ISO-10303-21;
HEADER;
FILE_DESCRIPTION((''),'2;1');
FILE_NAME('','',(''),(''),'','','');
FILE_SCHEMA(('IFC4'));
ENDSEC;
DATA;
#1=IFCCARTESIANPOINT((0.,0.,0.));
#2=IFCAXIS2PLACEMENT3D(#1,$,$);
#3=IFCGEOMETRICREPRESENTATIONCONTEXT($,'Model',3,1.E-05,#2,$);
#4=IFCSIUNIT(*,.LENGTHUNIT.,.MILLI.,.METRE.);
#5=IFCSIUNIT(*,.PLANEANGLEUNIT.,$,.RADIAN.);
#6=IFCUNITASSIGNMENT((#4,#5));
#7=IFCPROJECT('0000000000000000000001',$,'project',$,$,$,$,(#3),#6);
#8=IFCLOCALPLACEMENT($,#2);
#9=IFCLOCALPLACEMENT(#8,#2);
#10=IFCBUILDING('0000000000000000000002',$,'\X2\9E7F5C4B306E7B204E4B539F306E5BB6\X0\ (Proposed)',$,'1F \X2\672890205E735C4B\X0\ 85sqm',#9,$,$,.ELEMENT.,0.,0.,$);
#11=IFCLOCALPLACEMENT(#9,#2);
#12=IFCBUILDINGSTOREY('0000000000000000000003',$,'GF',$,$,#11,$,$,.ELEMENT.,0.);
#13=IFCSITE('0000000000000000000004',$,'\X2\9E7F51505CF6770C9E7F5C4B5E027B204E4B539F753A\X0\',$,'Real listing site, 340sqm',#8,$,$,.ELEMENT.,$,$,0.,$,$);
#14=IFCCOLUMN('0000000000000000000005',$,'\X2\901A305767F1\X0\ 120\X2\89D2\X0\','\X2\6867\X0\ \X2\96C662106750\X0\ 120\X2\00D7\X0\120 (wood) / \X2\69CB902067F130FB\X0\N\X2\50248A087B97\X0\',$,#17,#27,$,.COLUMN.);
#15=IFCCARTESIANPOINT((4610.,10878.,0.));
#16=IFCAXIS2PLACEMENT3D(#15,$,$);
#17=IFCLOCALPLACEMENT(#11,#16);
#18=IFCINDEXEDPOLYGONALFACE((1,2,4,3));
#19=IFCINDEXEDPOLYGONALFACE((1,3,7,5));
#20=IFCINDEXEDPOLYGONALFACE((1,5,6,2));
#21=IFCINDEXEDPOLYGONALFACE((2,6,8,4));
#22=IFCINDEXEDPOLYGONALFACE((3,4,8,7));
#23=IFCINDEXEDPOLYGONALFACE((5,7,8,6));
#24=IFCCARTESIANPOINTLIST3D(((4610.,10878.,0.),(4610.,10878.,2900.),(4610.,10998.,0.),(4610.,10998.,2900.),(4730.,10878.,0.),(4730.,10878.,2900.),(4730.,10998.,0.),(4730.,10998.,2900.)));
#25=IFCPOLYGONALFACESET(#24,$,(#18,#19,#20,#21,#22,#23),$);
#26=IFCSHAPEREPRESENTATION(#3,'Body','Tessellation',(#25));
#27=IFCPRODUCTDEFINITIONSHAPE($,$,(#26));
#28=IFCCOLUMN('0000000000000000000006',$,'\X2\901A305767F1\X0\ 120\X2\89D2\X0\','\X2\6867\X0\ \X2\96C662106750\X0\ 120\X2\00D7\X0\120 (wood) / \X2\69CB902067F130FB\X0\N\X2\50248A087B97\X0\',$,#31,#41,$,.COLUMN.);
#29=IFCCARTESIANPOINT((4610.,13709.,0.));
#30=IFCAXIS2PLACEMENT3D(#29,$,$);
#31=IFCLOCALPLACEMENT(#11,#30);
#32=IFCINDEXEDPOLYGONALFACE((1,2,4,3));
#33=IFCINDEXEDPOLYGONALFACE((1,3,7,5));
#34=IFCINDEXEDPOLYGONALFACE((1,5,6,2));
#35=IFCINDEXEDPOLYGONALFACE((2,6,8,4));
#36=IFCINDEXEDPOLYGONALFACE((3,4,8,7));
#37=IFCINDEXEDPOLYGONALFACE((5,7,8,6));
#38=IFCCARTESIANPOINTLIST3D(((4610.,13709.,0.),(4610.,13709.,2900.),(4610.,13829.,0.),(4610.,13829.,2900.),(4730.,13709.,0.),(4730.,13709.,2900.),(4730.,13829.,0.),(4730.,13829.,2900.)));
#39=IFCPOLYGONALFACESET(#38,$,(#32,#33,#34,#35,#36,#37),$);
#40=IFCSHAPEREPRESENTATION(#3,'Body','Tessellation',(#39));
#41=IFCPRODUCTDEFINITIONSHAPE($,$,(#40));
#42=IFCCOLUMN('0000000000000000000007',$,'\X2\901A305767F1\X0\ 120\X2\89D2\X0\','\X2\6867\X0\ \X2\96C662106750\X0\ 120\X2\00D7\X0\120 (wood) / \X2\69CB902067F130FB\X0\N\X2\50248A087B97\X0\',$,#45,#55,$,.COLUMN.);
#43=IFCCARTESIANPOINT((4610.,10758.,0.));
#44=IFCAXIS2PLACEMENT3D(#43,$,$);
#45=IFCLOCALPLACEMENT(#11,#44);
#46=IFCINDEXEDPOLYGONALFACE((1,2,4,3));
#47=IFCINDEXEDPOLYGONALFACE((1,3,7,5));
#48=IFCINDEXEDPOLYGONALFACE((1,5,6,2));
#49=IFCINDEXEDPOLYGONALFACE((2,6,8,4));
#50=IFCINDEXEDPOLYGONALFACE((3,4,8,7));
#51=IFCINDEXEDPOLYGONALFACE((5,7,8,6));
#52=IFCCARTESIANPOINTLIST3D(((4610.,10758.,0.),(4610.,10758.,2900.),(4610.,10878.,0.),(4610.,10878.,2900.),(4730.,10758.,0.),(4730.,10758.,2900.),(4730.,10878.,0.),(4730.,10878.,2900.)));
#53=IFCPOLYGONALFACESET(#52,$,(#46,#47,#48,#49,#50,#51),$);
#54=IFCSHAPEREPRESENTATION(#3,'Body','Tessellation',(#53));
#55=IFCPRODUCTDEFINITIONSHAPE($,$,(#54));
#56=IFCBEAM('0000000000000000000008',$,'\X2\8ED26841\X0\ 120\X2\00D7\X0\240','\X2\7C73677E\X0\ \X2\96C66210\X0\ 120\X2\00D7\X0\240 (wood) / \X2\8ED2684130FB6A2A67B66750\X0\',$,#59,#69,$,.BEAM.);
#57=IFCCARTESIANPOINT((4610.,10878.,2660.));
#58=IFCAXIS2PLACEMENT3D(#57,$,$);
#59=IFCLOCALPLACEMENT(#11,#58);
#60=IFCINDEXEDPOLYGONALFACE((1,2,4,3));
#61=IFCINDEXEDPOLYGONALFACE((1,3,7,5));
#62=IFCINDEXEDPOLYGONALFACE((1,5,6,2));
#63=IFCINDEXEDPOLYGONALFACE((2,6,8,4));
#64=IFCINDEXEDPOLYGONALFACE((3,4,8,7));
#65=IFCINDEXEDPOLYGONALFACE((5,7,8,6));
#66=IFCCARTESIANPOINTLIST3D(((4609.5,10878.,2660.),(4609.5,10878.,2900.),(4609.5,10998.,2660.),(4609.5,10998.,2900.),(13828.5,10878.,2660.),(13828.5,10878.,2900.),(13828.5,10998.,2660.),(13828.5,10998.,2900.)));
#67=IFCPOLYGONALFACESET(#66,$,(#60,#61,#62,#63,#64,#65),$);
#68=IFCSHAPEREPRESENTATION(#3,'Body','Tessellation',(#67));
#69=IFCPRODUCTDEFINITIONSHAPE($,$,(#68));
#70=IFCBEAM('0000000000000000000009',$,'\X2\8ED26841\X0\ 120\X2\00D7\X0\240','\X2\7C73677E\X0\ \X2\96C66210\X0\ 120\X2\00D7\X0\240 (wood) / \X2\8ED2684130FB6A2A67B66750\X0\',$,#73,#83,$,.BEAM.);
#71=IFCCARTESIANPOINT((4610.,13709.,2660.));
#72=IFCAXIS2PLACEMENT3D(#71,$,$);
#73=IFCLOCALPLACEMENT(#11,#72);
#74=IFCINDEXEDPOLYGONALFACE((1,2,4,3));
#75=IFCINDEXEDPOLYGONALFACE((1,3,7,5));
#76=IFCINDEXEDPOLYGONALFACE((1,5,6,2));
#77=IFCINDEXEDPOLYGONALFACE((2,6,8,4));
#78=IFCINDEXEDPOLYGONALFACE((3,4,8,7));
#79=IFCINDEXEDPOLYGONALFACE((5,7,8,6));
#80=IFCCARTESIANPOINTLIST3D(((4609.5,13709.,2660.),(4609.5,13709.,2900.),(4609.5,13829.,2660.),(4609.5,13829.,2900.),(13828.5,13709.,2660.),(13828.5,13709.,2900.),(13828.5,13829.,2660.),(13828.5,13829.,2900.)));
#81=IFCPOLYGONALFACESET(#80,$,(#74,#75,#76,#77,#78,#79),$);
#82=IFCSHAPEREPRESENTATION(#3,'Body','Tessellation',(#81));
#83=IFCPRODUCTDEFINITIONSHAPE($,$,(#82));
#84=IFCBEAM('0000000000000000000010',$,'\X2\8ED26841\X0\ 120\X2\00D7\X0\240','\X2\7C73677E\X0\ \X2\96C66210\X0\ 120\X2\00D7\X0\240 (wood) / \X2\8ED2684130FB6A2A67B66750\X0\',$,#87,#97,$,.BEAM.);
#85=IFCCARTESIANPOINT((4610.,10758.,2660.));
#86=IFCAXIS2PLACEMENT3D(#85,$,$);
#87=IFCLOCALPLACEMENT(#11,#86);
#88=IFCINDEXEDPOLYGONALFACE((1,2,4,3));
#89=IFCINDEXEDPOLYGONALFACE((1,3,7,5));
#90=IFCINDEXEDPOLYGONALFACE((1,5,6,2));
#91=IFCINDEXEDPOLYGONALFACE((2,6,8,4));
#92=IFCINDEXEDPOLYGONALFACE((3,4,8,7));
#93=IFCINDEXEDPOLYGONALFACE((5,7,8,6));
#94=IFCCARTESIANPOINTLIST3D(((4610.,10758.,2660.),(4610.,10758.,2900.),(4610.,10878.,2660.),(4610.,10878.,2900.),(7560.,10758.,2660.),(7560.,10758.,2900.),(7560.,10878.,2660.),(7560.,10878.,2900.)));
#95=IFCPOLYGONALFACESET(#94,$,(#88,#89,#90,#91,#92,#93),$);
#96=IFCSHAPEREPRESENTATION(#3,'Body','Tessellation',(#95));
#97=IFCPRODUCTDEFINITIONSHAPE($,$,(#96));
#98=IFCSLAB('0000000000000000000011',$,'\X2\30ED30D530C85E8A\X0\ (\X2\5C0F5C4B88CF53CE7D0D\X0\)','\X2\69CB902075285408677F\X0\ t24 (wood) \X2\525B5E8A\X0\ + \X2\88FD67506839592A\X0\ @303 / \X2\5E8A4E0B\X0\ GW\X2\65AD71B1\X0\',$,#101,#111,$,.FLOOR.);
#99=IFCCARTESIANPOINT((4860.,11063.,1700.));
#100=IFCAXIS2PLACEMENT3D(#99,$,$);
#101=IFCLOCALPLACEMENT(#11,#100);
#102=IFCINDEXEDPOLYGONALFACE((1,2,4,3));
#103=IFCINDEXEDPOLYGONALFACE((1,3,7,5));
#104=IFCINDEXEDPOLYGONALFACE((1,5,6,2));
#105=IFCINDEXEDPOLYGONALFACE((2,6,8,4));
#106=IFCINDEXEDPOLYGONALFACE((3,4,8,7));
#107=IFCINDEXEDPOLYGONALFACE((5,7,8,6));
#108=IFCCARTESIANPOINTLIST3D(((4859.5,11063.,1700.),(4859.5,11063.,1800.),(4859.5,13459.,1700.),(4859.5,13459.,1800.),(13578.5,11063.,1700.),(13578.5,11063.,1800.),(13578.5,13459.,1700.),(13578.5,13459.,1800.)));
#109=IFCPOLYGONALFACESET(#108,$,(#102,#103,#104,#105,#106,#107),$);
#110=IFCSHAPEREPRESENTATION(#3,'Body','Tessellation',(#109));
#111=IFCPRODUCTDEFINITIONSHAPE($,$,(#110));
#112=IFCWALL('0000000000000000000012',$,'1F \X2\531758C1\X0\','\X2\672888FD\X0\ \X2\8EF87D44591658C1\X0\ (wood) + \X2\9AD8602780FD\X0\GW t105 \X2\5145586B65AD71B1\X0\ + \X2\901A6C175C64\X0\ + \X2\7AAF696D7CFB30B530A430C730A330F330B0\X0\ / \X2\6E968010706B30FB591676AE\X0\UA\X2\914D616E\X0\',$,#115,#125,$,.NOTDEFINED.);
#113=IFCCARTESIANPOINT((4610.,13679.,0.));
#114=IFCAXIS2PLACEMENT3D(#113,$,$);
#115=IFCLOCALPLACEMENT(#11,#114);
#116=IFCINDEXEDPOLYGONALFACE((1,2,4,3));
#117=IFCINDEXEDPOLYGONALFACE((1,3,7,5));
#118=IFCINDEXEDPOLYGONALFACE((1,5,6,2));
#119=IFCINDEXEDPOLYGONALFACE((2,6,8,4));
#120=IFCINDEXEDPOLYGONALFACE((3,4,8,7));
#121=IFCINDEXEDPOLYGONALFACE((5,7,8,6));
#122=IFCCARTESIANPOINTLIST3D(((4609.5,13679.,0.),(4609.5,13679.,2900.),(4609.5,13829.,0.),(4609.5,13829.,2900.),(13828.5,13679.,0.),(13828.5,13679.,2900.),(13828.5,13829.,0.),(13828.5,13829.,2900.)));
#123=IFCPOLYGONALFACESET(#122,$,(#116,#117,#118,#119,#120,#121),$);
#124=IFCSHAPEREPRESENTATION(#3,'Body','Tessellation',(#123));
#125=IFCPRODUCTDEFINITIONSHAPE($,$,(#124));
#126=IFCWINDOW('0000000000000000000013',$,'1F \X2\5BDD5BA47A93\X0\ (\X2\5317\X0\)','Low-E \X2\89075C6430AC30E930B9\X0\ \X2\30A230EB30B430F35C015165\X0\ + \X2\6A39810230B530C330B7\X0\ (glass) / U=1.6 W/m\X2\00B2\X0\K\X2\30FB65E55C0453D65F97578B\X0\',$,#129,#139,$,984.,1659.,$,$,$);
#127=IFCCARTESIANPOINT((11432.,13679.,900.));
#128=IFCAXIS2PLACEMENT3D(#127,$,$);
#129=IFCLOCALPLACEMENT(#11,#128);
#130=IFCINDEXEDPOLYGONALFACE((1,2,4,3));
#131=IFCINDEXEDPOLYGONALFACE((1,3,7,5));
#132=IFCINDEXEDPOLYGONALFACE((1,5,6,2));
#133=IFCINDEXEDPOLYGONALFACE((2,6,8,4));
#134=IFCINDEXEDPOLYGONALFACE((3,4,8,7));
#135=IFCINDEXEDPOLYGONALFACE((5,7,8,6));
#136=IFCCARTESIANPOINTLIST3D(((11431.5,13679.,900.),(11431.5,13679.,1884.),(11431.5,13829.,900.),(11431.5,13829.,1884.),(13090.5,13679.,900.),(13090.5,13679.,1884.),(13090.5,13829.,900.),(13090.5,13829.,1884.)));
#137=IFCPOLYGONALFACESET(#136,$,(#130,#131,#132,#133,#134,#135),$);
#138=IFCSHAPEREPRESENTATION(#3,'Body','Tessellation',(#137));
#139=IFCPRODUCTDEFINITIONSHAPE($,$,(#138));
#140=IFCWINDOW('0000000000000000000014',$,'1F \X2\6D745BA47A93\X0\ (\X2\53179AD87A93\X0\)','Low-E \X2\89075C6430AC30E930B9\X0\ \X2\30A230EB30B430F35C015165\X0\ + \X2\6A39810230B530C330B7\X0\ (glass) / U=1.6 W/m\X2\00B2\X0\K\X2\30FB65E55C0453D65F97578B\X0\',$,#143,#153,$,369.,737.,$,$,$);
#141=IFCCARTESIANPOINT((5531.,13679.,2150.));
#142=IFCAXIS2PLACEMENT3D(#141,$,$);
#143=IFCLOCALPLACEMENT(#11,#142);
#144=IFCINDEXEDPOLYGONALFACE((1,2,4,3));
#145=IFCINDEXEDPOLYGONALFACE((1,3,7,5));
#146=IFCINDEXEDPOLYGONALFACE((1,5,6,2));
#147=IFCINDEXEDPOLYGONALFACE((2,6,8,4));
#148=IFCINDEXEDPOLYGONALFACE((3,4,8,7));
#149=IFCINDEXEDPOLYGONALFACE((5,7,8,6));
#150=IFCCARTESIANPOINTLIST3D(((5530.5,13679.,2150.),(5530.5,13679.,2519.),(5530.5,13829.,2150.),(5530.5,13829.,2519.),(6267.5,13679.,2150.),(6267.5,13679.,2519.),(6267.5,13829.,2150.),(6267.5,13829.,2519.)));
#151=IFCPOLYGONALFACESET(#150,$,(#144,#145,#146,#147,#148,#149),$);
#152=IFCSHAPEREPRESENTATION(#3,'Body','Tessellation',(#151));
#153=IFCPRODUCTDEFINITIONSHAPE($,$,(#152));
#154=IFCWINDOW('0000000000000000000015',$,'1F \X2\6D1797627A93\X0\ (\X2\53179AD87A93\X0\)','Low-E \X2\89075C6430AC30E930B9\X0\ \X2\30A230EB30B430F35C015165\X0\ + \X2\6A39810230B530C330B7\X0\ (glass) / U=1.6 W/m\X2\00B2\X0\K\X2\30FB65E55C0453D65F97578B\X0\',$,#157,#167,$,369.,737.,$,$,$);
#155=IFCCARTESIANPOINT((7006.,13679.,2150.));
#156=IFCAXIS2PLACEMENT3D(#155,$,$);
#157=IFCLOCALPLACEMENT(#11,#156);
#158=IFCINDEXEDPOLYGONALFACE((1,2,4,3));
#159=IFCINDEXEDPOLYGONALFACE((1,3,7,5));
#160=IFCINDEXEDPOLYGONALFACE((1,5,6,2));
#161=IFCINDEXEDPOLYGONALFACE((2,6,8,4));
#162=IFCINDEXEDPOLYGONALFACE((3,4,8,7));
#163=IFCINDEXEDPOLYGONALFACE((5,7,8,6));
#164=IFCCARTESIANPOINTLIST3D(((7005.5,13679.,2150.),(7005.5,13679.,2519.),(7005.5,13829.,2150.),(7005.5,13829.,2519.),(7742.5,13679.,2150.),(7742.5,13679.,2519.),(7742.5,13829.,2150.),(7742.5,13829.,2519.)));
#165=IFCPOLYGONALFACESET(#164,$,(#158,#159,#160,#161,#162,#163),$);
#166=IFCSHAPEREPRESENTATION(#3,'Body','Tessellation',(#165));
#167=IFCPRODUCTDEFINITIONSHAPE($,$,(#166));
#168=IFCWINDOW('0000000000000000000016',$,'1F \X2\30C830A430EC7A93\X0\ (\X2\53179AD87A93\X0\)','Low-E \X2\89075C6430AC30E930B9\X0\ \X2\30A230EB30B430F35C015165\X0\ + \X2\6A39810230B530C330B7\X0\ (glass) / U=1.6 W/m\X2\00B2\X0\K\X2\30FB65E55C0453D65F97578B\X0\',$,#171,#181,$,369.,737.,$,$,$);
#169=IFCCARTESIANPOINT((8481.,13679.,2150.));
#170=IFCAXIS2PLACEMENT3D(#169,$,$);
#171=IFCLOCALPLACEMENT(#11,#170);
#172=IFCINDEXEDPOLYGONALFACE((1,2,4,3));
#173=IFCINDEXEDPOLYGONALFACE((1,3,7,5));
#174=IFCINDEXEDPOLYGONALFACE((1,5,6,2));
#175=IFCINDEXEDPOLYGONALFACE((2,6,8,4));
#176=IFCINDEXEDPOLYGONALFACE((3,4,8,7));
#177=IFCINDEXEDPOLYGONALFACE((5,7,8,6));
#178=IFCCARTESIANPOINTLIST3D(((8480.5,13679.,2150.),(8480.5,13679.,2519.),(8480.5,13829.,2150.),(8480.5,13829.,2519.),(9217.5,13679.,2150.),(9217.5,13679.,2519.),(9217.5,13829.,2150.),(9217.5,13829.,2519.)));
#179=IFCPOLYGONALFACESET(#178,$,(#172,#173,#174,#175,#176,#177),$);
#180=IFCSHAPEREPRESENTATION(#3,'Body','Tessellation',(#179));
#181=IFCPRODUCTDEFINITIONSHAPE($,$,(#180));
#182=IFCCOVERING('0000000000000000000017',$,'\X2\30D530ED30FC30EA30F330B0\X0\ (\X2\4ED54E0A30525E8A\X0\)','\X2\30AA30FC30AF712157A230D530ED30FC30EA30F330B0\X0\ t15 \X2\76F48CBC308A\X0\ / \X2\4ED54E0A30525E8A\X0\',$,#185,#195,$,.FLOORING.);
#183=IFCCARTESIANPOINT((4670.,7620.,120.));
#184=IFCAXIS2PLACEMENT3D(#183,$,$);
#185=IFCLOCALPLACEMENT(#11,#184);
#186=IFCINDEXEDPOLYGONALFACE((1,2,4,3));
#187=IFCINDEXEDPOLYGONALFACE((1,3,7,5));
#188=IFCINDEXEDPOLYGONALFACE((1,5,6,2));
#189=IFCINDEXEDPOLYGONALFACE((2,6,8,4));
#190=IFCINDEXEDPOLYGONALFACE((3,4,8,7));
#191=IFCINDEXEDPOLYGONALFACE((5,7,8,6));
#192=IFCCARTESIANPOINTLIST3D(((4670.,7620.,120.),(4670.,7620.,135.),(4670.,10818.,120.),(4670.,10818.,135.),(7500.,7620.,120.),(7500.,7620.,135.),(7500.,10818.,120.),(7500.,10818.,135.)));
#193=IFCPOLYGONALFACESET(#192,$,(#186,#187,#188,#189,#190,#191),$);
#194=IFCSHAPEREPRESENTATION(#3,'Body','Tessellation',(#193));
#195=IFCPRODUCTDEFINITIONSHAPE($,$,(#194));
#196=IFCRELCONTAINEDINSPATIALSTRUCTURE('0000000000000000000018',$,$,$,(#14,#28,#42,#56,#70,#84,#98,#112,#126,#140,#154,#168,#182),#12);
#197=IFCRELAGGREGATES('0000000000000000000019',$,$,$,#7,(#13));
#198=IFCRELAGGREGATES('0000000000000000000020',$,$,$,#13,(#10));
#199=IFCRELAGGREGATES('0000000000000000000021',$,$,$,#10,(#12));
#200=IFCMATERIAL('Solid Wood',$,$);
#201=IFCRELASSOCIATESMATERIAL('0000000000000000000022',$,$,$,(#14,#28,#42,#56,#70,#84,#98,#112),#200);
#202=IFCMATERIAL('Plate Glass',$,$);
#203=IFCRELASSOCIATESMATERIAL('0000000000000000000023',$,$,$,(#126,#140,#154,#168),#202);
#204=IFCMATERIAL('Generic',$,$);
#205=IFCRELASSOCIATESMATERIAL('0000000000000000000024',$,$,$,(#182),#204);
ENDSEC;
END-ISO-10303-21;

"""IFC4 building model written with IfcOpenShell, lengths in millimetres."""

from ifc_helpers import new_model, si_unit, frame, frame_2d, origin, place, context, project, spatial, rectangle, extrude, material, element, fill, save


model = new_model("IFC4")

# Units and contexts
model_context = context("Model", 3, precision=1e-05, world=origin())
ifc_project = project(units=[si_unit("LENGTHUNIT", "METRE", prefix="MILLI"), si_unit("PLANEANGLEUNIT", "RADIAN")], contexts=[model_context])

# Site, building, storey
site_placement = place(None, origin())
site = spatial("IfcSite", under=ifc_project, at=site_placement, Name="鹿児島県鹿屋市笠之原町", ObjectType="Real listing site, 340sqm", CompositionType="ELEMENT", RefElevation=0.0)
building_placement = place(site_placement, origin())
building = spatial("IfcBuilding", under=site, at=building_placement, Name="鹿屋の笠之原の家 (Proposed)", ObjectType="1F 木造平屋 85sqm", CompositionType="ELEMENT", ElevationOfRefHeight=0.0, ElevationOfTerrain=0.0)
storey_placement = place(building_placement, origin())
storey = spatial("IfcBuildingStorey", under=building, at=storey_placement, Name="GF", CompositionType="ELEMENT", Elevation=0.0)

# Columns
ifc_material_1 = material(Name="Solid Wood")
column_1_placement = place(storey_placement, frame((4610.0, 10878.0, 0.0)))
element("IfcColumn", 1, at=column_1_placement, inside=storey, material=ifc_material_1, Name="通し柱 120角", Description="桧 集成材 120×120 (wood) / 構造柱・N値計算", PredefinedType="COLUMN", context=model_context, shape_type="SweptSolid", body=[
    extrude(rectangle(XDim=120.0, YDim=120.0, at=frame_2d((60.0, 60.0))), frame((4610.0, 10878.0, 0.0)), (0.0, 0.0, 1.0), 2900.0),
])
column_2_placement = place(storey_placement, frame((4610.0, 13709.0, 0.0)))
element("IfcColumn", 2, at=column_2_placement, inside=storey, material=ifc_material_1, Name="通し柱 120角", Description="桧 集成材 120×120 (wood) / 構造柱・N値計算", PredefinedType="COLUMN", context=model_context, shape_type="SweptSolid", body=[
    extrude(rectangle(XDim=120.0, YDim=120.0, at=frame_2d((60.0, 60.0))), frame((4610.0, 13709.0, 0.0)), (0.0, 0.0, 1.0), 2900.0),
])
column_3_placement = place(storey_placement, frame((4610.0, 10758.0, 0.0)))
element("IfcColumn", 3, at=column_3_placement, inside=storey, material=ifc_material_1, Name="通し柱 120角", Description="桧 集成材 120×120 (wood) / 構造柱・N値計算", PredefinedType="COLUMN", context=model_context, shape_type="SweptSolid", body=[
    extrude(rectangle(XDim=120.0, YDim=120.0, at=frame_2d((60.0, 60.0))), frame((4610.0, 10758.0, 0.0)), (0.0, 0.0, 1.0), 2900.0),
])

# Beams
beam_1_placement = place(storey_placement, frame((4610.0, 10878.0, 2660.0)))
element("IfcBeam", 4, at=beam_1_placement, inside=storey, material=ifc_material_1, Name="軒桁 120×240", Description="米松 集成 120×240 (wood) / 軒桁・横架材", PredefinedType="BEAM", context=model_context, shape_type="SweptSolid", body=[
    extrude(rectangle(XDim=9219.0, YDim=120.0, at=frame_2d((4609.0, 60.0))), frame((4610.0, 10878.0, 2660.0)), (0.0, 0.0, 1.0), 240.0),
])
beam_2_placement = place(storey_placement, frame((4610.0, 13709.0, 2660.0)))
element("IfcBeam", 5, at=beam_2_placement, inside=storey, material=ifc_material_1, Name="軒桁 120×240", Description="米松 集成 120×240 (wood) / 軒桁・横架材", PredefinedType="BEAM", context=model_context, shape_type="SweptSolid", body=[
    extrude(rectangle(XDim=9219.0, YDim=120.0, at=frame_2d((4609.0, 60.0))), frame((4610.0, 13709.0, 2660.0)), (0.0, 0.0, 1.0), 240.0),
])
beam_3_placement = place(storey_placement, frame((4610.0, 10758.0, 2660.0)))
element("IfcBeam", 6, at=beam_3_placement, inside=storey, material=ifc_material_1, Name="軒桁 120×240", Description="米松 集成 120×240 (wood) / 軒桁・横架材", PredefinedType="BEAM", context=model_context, shape_type="SweptSolid", body=[
    extrude(rectangle(XDim=2950.0, YDim=120.0, at=frame_2d((1475.0, 60.0))), frame((4610.0, 10758.0, 2660.0)), (0.0, 0.0, 1.0), 240.0),
])

# Slab
slab_1_placement = place(storey_placement, frame((4860.0, 11063.0, 1700.0)))
element("IfcSlab", 7, at=slab_1_placement, inside=storey, material=ifc_material_1, Name="ロフト床 (小屋裏収納)", Description="構造用合板 t24 (wood) 剛床 + 製材根太 @303 / 床下 GW断熱", PredefinedType="FLOOR", context=model_context, shape_type="SweptSolid", body=[
    extrude(rectangle(XDim=8719.0, YDim=2396.0, at=frame_2d((4359.0, 1198.0))), frame((4860.0, 11063.0, 1700.0)), (0.0, 0.0, 1.0), 100.0),
])

# Wall, openings, windows
wall_1_placement = place(storey_placement, frame((4610.0, 13679.0, 0.0)))
wall_1 = element("IfcWall", 8, at=wall_1_placement, inside=storey, material=ifc_material_1, Name="1F 北壁", Description="木製 軸組外壁 (wood) + 高性能GW t105 充填断熱 + 通気層 + 窯業系サイディング / 準耐火・外皮UA配慮", PredefinedType="NOTDEFINED", context=model_context, shape_type="SweptSolid", body=[
    extrude(rectangle(XDim=9219.0, YDim=150.0, at=frame_2d((4609.0, 75.0))), frame((4610.0, 13679.0, 0.0)), (0.0, 0.0, 1.0), 2900.0),
])
opening_1_placement = place(storey_placement, frame((11432.0, 13679.0, 900.0)))
opening_1 = element("IfcOpeningElement", 9, at=opening_1_placement, cuts=wall_1, PredefinedType="NOTDEFINED", context=model_context, shape_type="SweptSolid", body=[
    extrude(rectangle(XDim=1659.0, YDim=150.0, at=frame_2d((829.0, 75.0))), frame((11432.0, 13679.0, 900.0)), (0.0, 0.0, 1.0), 984.0),
])
opening_2_placement = place(storey_placement, frame((5531.0, 13679.0, 2150.0)))
opening_2 = element("IfcOpeningElement", 10, at=opening_2_placement, cuts=wall_1, PredefinedType="NOTDEFINED", context=model_context, shape_type="SweptSolid", body=[
    extrude(rectangle(XDim=737.0, YDim=150.0, at=frame_2d((368.0, 75.0))), frame((5531.0, 13679.0, 2150.0)), (0.0, 0.0, 1.0), 369.0),
])
opening_3_placement = place(storey_placement, frame((7006.0, 13679.0, 2150.0)))
opening_3 = element("IfcOpeningElement", 11, at=opening_3_placement, cuts=wall_1, PredefinedType="NOTDEFINED", context=model_context, shape_type="SweptSolid", body=[
    extrude(rectangle(XDim=737.0, YDim=150.0, at=frame_2d((368.0, 75.0))), frame((7006.0, 13679.0, 2150.0)), (0.0, 0.0, 1.0), 369.0),
])
opening_4_placement = place(storey_placement, frame((8481.0, 13679.0, 2150.0)))
opening_4 = element("IfcOpeningElement", 12, at=opening_4_placement, cuts=wall_1, PredefinedType="NOTDEFINED", context=model_context, shape_type="SweptSolid", body=[
    extrude(rectangle(XDim=737.0, YDim=150.0, at=frame_2d((368.0, 75.0))), frame((8481.0, 13679.0, 2150.0)), (0.0, 0.0, 1.0), 369.0),
])
ifc_material_2 = material(Name="Plate Glass")
window_1_placement = place(storey_placement, frame((11432.0, 13679.0, 900.0)))
window_1 = element("IfcWindow", 13, at=window_1_placement, inside=storey, material=ifc_material_2, Name="1F 寝室窓 (北)", Description="Low-E 複層ガラス アルゴン封入 + 樹脂サッシ (glass) / U=1.6 W/m²K・日射取得型", OverallHeight=984.0, OverallWidth=1659.0, context=model_context, shape_type="SweptSolid", body=[
    extrude(rectangle(XDim=1659.0, YDim=150.0, at=frame_2d((829.0, 75.0))), frame((11432.0, 13679.0, 900.0)), (0.0, 0.0, 1.0), 984.0),
])
fill(opening_1, window_1)
window_2_placement = place(storey_placement, frame((5531.0, 13679.0, 2150.0)))
window_2 = element("IfcWindow", 14, at=window_2_placement, inside=storey, material=ifc_material_2, Name="1F 浴室窓 (北高窓)", Description="Low-E 複層ガラス アルゴン封入 + 樹脂サッシ (glass) / U=1.6 W/m²K・日射取得型", OverallHeight=369.0, OverallWidth=737.0, context=model_context, shape_type="SweptSolid", body=[
    extrude(rectangle(XDim=737.0, YDim=150.0, at=frame_2d((368.0, 75.0))), frame((5531.0, 13679.0, 2150.0)), (0.0, 0.0, 1.0), 369.0),
])
fill(opening_2, window_2)
window_3_placement = place(storey_placement, frame((7006.0, 13679.0, 2150.0)))
window_3 = element("IfcWindow", 15, at=window_3_placement, inside=storey, material=ifc_material_2, Name="1F 洗面窓 (北高窓)", Description="Low-E 複層ガラス アルゴン封入 + 樹脂サッシ (glass) / U=1.6 W/m²K・日射取得型", OverallHeight=369.0, OverallWidth=737.0, context=model_context, shape_type="SweptSolid", body=[
    extrude(rectangle(XDim=737.0, YDim=150.0, at=frame_2d((368.0, 75.0))), frame((7006.0, 13679.0, 2150.0)), (0.0, 0.0, 1.0), 369.0),
])
fill(opening_3, window_3)
window_4_placement = place(storey_placement, frame((8481.0, 13679.0, 2150.0)))
window_4 = element("IfcWindow", 16, at=window_4_placement, inside=storey, material=ifc_material_2, Name="1F トイレ窓 (北高窓)", Description="Low-E 複層ガラス アルゴン封入 + 樹脂サッシ (glass) / U=1.6 W/m²K・日射取得型", OverallHeight=369.0, OverallWidth=737.0, context=model_context, shape_type="SweptSolid", body=[
    extrude(rectangle(XDim=737.0, YDim=150.0, at=frame_2d((368.0, 75.0))), frame((8481.0, 13679.0, 2150.0)), (0.0, 0.0, 1.0), 369.0),
])
fill(opening_4, window_4)

# Covering
ifc_material_3 = material(Name="Generic")
covering_1_placement = place(storey_placement, frame((4670.0, 7620.0, 120.0)))
element("IfcCovering", 17, at=covering_1_placement, inside=storey, material=ifc_material_3, Name="フローリング (仕上げ床)", Description="オーク無垢フローリング t15 直貼り / 仕上げ床", PredefinedType="FLOORING", context=model_context, shape_type="SweptSolid", body=[
    extrude(rectangle(XDim=2830.0, YDim=3198.0, at=frame_2d((1415.0, 1599.0))), frame((4670.0, 7620.0, 120.0)), (0.0, 0.0, 1.0), 15.0),
])

save(model, "model.ifc")
